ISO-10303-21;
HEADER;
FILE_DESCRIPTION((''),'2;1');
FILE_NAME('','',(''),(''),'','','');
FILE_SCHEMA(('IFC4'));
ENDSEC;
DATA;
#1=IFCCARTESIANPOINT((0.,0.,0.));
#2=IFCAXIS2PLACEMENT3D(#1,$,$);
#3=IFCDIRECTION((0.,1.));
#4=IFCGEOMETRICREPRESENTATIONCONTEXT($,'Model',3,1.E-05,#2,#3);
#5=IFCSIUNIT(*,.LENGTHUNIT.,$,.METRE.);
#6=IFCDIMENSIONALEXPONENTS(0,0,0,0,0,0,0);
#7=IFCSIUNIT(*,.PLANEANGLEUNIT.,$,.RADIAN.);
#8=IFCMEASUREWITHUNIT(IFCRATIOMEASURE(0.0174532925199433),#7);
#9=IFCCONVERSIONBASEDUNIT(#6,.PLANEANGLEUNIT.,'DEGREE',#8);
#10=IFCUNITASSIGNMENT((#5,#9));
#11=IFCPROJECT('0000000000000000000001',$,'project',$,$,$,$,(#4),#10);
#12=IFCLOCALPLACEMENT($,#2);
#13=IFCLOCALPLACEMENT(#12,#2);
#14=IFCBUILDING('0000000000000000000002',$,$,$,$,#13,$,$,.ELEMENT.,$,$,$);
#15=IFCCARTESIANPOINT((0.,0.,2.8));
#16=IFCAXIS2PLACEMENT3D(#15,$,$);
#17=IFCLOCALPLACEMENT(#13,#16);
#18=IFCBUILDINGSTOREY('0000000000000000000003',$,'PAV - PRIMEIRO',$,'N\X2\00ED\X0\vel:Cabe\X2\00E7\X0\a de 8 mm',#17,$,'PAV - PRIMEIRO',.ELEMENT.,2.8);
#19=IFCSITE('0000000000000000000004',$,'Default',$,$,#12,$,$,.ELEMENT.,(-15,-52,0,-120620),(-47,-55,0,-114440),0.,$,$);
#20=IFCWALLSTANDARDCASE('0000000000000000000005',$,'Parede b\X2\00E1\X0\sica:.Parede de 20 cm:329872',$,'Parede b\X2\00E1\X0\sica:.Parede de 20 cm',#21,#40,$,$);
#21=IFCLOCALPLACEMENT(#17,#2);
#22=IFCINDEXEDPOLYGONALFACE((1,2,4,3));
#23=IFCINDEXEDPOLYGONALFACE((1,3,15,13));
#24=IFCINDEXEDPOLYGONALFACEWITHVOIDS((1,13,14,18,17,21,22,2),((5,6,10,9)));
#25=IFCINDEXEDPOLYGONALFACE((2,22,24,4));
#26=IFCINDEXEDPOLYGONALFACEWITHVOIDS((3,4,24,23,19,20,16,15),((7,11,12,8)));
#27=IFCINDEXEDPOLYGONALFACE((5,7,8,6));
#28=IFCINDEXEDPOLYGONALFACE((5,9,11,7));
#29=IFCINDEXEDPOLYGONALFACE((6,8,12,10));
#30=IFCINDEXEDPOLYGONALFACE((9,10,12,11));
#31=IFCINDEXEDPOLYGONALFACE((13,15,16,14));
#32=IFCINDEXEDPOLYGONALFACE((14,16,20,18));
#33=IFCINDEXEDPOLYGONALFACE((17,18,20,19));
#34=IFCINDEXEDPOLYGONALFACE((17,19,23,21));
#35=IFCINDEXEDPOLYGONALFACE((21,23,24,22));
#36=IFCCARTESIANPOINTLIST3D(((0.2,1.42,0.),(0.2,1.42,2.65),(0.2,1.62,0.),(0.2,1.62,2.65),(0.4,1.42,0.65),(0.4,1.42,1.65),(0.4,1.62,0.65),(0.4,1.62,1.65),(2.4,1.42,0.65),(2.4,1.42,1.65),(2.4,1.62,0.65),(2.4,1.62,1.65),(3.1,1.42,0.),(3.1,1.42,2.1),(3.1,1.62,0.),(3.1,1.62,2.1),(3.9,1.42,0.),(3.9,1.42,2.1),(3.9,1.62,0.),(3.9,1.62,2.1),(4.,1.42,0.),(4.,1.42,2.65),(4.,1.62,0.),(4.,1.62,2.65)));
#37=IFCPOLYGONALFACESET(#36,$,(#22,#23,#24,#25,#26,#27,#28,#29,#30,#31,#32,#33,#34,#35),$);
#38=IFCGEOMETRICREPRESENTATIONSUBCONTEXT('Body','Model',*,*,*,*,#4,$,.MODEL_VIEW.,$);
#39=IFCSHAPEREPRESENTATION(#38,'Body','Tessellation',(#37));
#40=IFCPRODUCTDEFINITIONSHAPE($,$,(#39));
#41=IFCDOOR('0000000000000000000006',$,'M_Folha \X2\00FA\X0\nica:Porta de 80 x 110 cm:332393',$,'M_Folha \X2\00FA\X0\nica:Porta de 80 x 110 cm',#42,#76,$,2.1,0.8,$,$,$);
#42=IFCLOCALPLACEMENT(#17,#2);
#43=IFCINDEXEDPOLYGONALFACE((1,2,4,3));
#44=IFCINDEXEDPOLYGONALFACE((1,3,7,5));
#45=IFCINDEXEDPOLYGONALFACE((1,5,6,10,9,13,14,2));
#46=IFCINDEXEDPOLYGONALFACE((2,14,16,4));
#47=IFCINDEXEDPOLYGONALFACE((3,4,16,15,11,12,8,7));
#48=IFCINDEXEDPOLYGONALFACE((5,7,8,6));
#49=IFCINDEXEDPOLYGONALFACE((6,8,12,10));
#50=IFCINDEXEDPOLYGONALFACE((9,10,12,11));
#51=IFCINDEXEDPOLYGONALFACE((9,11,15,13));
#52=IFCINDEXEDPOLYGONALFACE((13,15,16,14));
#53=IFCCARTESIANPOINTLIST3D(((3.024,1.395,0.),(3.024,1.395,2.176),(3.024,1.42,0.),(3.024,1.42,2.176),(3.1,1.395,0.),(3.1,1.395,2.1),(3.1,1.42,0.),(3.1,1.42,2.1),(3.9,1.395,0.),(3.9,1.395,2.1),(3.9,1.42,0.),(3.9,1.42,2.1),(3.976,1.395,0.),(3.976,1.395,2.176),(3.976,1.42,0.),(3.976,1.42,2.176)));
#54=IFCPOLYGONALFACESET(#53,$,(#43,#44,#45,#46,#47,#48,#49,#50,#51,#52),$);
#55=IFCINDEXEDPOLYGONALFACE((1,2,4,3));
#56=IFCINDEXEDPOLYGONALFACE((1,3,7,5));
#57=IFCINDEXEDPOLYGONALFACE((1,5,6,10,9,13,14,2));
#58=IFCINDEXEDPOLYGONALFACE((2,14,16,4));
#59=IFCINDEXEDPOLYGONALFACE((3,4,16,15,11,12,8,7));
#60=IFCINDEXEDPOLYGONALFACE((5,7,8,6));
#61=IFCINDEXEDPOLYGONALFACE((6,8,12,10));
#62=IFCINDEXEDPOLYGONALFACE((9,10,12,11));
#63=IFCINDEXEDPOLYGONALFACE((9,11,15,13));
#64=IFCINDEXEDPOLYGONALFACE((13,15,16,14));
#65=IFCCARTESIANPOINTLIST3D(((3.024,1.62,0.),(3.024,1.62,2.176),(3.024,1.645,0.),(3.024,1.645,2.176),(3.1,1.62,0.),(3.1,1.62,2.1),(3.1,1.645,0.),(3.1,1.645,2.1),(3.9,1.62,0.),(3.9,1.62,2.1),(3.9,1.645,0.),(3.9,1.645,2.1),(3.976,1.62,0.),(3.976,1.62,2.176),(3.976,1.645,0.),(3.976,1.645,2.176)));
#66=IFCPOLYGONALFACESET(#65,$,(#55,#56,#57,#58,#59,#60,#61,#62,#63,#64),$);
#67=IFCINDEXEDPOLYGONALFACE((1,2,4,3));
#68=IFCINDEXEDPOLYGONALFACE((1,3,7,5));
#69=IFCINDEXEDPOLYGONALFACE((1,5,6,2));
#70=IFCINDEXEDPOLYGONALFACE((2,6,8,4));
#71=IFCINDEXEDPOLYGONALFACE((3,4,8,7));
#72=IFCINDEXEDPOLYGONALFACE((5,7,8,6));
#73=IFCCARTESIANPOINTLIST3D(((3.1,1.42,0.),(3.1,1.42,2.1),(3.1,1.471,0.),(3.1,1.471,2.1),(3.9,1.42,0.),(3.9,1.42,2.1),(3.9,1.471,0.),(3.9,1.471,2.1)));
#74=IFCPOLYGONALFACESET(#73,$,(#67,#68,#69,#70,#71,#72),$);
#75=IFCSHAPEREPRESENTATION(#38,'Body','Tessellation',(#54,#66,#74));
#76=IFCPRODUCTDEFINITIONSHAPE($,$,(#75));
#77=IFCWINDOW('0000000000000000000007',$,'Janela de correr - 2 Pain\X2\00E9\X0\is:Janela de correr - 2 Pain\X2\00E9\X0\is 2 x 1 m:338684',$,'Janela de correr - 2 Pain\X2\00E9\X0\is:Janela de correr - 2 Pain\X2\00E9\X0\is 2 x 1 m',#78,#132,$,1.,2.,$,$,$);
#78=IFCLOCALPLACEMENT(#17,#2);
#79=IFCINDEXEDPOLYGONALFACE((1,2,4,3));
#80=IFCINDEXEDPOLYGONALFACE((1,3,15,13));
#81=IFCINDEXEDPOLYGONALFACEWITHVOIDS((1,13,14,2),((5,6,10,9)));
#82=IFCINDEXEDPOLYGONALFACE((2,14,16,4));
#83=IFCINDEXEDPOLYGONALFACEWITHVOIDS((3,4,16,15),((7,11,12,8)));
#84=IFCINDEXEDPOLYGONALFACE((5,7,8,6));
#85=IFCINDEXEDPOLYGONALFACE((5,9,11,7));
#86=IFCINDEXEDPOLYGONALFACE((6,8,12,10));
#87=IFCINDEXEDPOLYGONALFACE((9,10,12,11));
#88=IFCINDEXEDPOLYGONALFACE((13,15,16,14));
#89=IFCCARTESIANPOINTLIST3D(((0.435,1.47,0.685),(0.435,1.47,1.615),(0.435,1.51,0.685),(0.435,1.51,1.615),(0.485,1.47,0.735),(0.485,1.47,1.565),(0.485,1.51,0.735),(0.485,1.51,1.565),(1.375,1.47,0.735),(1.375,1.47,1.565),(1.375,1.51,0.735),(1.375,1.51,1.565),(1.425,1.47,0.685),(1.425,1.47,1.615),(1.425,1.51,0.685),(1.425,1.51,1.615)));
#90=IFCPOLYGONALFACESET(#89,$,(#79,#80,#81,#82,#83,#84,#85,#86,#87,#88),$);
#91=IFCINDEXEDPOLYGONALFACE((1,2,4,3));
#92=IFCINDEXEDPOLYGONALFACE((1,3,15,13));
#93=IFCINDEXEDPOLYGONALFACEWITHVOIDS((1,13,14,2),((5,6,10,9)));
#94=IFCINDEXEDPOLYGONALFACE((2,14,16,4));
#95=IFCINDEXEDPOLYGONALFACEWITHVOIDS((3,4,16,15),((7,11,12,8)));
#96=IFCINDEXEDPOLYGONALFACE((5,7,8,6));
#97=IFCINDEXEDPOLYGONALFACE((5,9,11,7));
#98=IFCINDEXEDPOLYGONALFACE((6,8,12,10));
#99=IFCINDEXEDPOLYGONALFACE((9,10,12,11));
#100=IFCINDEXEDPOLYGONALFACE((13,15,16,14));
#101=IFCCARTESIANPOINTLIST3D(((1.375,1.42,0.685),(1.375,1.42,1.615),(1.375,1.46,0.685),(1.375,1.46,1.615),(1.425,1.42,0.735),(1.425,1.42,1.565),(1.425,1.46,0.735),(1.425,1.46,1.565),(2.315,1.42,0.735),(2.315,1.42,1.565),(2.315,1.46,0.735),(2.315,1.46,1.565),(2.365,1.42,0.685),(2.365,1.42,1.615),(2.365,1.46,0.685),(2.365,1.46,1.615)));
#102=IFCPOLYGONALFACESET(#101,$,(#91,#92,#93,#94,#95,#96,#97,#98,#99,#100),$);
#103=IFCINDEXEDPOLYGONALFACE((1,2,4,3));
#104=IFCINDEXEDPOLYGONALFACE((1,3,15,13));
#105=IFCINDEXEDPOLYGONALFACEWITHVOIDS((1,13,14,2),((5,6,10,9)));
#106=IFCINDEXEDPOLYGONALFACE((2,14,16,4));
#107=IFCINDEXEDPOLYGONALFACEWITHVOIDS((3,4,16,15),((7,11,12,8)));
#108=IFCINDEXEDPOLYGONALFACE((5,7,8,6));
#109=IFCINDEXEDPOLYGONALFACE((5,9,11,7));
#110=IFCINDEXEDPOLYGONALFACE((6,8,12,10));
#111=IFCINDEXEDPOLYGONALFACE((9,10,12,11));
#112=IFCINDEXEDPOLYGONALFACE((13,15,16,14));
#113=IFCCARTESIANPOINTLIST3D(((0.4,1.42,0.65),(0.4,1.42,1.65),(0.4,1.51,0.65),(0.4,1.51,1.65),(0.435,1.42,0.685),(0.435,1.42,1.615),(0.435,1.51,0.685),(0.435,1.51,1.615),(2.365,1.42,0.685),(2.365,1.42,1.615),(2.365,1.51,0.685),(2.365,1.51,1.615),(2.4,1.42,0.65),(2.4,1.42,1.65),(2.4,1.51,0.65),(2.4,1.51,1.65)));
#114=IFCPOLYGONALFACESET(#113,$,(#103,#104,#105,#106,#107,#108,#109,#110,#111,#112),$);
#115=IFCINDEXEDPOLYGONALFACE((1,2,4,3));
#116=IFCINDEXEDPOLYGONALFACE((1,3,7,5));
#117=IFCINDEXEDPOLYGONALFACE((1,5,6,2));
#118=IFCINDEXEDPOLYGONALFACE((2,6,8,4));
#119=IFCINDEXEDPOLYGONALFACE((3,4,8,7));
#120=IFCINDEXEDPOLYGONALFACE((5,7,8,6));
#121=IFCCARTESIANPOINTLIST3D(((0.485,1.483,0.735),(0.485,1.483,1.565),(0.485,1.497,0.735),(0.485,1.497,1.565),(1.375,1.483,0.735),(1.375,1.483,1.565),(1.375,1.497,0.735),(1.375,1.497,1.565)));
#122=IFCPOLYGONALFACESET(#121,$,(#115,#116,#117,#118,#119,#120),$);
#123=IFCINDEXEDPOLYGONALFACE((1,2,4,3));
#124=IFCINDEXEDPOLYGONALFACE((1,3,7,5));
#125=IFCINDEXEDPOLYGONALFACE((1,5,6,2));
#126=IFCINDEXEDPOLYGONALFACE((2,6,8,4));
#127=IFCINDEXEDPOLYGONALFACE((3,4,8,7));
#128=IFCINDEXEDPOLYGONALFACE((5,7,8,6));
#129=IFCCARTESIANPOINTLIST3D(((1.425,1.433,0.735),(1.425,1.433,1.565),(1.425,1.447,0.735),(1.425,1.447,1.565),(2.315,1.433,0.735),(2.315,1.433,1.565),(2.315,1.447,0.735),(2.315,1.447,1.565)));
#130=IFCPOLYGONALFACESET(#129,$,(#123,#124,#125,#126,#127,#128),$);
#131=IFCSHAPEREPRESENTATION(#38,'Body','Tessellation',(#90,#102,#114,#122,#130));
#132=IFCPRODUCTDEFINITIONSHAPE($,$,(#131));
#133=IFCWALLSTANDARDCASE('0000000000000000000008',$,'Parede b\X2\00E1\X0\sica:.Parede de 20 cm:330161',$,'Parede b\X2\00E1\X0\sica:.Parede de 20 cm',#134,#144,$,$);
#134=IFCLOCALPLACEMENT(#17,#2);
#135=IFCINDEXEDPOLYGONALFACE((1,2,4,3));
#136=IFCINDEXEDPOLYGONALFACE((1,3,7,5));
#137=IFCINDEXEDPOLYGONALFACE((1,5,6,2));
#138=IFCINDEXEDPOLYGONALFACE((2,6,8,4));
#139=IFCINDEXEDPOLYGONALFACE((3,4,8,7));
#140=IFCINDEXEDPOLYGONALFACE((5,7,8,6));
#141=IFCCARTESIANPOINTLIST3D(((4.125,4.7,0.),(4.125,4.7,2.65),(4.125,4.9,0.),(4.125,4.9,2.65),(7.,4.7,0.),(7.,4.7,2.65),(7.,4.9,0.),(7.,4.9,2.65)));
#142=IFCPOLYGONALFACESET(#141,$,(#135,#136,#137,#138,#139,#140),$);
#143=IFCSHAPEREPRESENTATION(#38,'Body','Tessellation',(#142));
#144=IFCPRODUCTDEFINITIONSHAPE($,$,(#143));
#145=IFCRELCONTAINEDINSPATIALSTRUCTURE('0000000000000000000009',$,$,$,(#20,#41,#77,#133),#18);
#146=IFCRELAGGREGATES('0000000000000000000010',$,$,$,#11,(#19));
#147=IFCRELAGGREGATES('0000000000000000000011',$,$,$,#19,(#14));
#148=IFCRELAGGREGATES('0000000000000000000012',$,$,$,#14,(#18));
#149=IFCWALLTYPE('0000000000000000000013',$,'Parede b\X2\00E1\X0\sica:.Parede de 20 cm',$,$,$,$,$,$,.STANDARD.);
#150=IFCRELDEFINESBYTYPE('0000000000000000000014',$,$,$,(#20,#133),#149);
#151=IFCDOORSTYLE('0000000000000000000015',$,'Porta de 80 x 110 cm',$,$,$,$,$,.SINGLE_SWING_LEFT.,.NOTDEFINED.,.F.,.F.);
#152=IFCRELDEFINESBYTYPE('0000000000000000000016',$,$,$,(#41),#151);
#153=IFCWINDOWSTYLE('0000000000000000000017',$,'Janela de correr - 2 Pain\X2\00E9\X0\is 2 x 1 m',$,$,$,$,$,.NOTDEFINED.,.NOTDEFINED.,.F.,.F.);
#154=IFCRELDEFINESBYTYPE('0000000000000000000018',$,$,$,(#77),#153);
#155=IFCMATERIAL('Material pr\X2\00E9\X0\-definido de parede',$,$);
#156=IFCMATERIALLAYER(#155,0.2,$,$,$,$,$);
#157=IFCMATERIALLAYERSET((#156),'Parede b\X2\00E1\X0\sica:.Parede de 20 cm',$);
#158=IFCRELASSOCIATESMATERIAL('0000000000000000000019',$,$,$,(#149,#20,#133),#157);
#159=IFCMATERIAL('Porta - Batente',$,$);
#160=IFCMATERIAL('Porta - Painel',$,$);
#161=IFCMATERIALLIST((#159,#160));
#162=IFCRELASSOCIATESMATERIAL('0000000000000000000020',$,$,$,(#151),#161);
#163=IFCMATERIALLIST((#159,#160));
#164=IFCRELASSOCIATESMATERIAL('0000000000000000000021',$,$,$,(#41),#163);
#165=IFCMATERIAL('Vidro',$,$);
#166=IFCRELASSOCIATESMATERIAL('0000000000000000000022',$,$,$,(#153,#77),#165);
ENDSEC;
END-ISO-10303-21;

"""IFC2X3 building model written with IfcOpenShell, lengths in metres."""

from ifc_helpers import new_model, entity, si_unit, converted_unit, direction, frame, frame_2d, origin, origin_2d_with_axis, place, context, subcontext, project, spatial, polyline, rectangle, outline, extrude, clip, bounded_halfspace, source, transform, mapped, material, material_list, layer, layer_set, layer_usage, type_object, type_shapes, element, fill, save


model = new_model("IFC2X3")

# Units and contexts
model_context = context("Model", 3, precision=1e-05, world=origin(), true_north=direction((0.0, 1.0)))
body_context = subcontext(model_context, "Body", "Model", "MODEL_VIEW")
ifc_project = project(units=[si_unit("LENGTHUNIT", "METRE"), converted_unit("PLANEANGLEUNIT", "DEGREE", entity("IfcRatioMeasure", 0.0174532925199433), si_unit("PLANEANGLEUNIT", "RADIAN"), dimensions=[0, 0, 0, 0, 0, 0, 0])], contexts=[model_context])

# Site, building, storey
site_placement = place(None, origin())
site = spatial("IfcSite", under=ifc_project, at=site_placement, Name="Default", CompositionType="ELEMENT", RefLatitude=(-15, -52, 0, -120620), RefLongitude=(-47, -55, 0, -114440), RefElevation=0.0)
building_placement = place(site_placement, origin())
building = spatial("IfcBuilding", under=site, at=building_placement, CompositionType="ELEMENT")
storey_placement = place(building_placement, frame((0.0, 0.0, 2.8)))
storey = spatial("IfcBuildingStorey", under=building, at=storey_placement, Name="PAV - PRIMEIRO", ObjectType="Nível:Cabeça de 8 mm", LongName="PAV - PRIMEIRO", CompositionType="ELEMENT", Elevation=2.8)

# Shared definitions
ifc_material_1 = material(Name="Material pré-definido de parede")
ifc_layer_1 = layer(ifc_material_1, 0.2)
ifc_layer_set_1 = layer_set([ifc_layer_1], Name="Parede básica:.Parede de 20 cm")
wall_type_1 = type_object("IfcWallType", Name="Parede básica:.Parede de 20 cm", PredefinedType="STANDARD", material=ifc_layer_set_1)

# Shared definitions
ifc_material_2 = material(Name="Vidro")

# Wall, openings, door, window
ifc_layer_usage_1 = layer_usage(ifc_layer_set_1, "AXIS2", "NEGATIVE", 0.1)
wall_1_placement = place(storey_placement, frame((0.2, 1.52, 0.0)))
wall_1 = element("IfcWallStandardCase", 1, at=wall_1_placement, inside=storey, type_object=wall_type_1, material=ifc_layer_usage_1, Name="Parede básica:.Parede de 20 cm:329872", ObjectType="Parede básica:.Parede de 20 cm", context=body_context, shape_type="Clipping", body=[
    clip(extrude(rectangle(XDim=3.8, YDim=0.2, at=frame_2d((1.9, 0.0), x_axis=(-1.0, 0.0))), origin(), (0.0, 0.0, 1.0), 2.65), bounded_halfspace(frame((0.0, -0.1, 2.65), z_axis=(0.0, 0.0, -1.0), x_axis=(0.0, -1.0, 0.0)), True, frame((0.0, -0.1, 2.65)), polyline([(0.0, 0.0), (3.8, 0.0), (3.8, 0.2), (0.0, 0.2), (0.0, 0.0)]))),
])
opening_1_placement = place(wall_1_placement, frame((3.7, 0.1, 0.0)))
opening_1 = element("IfcOpeningElement", 2, at=opening_1_placement, cuts=wall_1, ObjectType="Opening", context=body_context, shape_type="SweptSolid", body=[
    extrude(rectangle(XDim=0.8, YDim=2.1, at=frame_2d((1.05, 0.4), x_axis=(0.0, -1.0))), frame((0.0, 0.0, 0.0), z_axis=(0.0, -1.0, 0.0), x_axis=(0.0, 0.0, 1.0)), (0.0, 0.0, 1.0), 0.2),
])
opening_2_placement = place(wall_1_placement, frame((0.2, -0.1, 0.65)))
opening_2 = element("IfcOpeningElement", 3, at=opening_2_placement, cuts=wall_1, ObjectType="Opening", context=body_context, shape_type="SweptSolid", body=[
    extrude(rectangle(XDim=1.0, YDim=2.0, at=frame_2d((0.5, 1.0), x_axis=(1.0, 0.0))), frame((0.0, 0.0, 0.0), z_axis=(0.0, 1.0, 0.0), x_axis=(0.0, 0.0, 1.0)), (0.0, 0.0, 1.0), 0.2),
])
ifc_material_3 = material(Name="Porta - Batente")
ifc_material_4 = material(Name="Porta - Painel")
ifc_material_list_1 = material_list([ifc_material_3, ifc_material_4])
ifc_material_list_2 = material_list([ifc_material_3, ifc_material_4])
door_style_1 = type_object("IfcDoorStyle", Name="Porta de 80 x 110 cm", ConstructionType="NOTDEFINED", OperationType="SINGLE_SWING_LEFT", ParameterTakesPrecedence=False, Sizeable=False, material=ifc_material_list_2)
shared_shape_1 = source(origin(), body_context, "Body", "SweptSolid", [
    extrude(outline(polyline([(-0.476, -1.107), (0.476, -1.107), (0.476, 1.069), (0.4, 1.069), (0.4, -1.031), (-0.4, -1.031), (-0.4, 1.069), (-0.476, 1.069), (-0.476, -1.107)])), frame((0.4, 0.225, 1.069), z_axis=(0.0, -1.0, 0.0), x_axis=(-1.0, 0.0, 0.0)), (0.0, 0.0, 1.0), 0.025),
    extrude(outline(polyline([(-1.107, -0.476), (1.069, -0.476), (1.069, -0.4), (-1.031, -0.4), (-1.031, 0.4), (1.069, 0.4), (1.069, 0.476), (-1.107, 0.476), (-1.107, -0.476)])), frame((0.4, 0.0, 1.069), z_axis=(0.0, -1.0, 0.0), x_axis=(0.0, 0.0, -1.0)), (0.0, 0.0, 1.0), 0.025),
    extrude(rectangle(XDim=0.8, YDim=0.051, at=frame_2d((0.0, 0.0), x_axis=(1.0, 0.0))), frame((0.4, 0.1745, 0.0)), (0.0, 0.0, 1.0), 2.1),
])
type_shapes(door_style_1, [shared_shape_1])
door_1_placement = place(opening_1_placement, frame((0.0, 0.0, 0.0), z_axis=(0.0, 0.0, 1.0), x_axis=(-1.0, 0.0, 0.0)))
door_1 = element("IfcDoor", 4, at=door_1_placement, inside=storey, type_object=door_style_1, material=ifc_material_list_1, Name="M_Folha única:Porta de 80 x 110 cm:332393", ObjectType="M_Folha única:Porta de 80 x 110 cm", OverallHeight=2.1, OverallWidth=0.8, context=body_context, shape_type="MappedRepresentation", body=[
    mapped(shared_shape_1, transform((0.0, 0.0, 0.0), scale=1.0)),
])
fill(opening_1, door_1)
window_style_1 = type_object("IfcWindowStyle", Name="Janela de correr - 2 Painéis 2 x 1 m", ConstructionType="NOTDEFINED", OperationType="NOTDEFINED", ParameterTakesPrecedence=False, Sizeable=False, material=ifc_material_2)
shared_shape_2 = source(origin(), body_context, "Body", "SweptSolid", [
    extrude(outline(polyline([(-0.495, -0.465), (0.495, -0.465), (0.495, 0.465), (-0.495, 0.465), (-0.495, -0.465)]), holes=[polyline([(-0.445, 0.415), (0.445, 0.415), (0.445, -0.415), (-0.445, -0.415), (-0.445, 0.415)])]), frame((0.53, 0.09, 0.5), z_axis=(0.0, -1.0, 0.0), x_axis=(-1.0, 0.0, 0.0)), (0.0, 0.0, 1.0), 0.04),
    extrude(outline(polyline([(-0.495, -0.465), (0.495, -0.465), (0.495, 0.465), (-0.495, 0.465), (-0.495, -0.465)]), holes=[polyline([(-0.445, 0.415), (0.445, 0.415), (0.445, -0.415), (-0.445, -0.415), (-0.445, 0.415)])]), frame((1.47, 0.04, 0.5), z_axis=(0.0, -1.0, 0.0), x_axis=(1.0, 0.0, 0.0)), (0.0, 0.0, 1.0), 0.04),
    extrude(outline(polyline([(-1.0, -0.5), (1.0, -0.5), (1.0, 0.5), (-1.0, 0.5), (-1.0, -0.5)]), holes=[polyline([(-0.965, 0.465), (0.965, 0.465), (0.965, -0.465), (-0.965, -0.465), (-0.965, 0.465)])]), frame((1.0, 0.09, 0.5), z_axis=(0.0, -1.0, 0.0), x_axis=(1.0, 0.0, 0.0)), (0.0, 0.0, 1.0), 0.09),
    extrude(rectangle(XDim=0.89, YDim=0.014, at=frame_2d((0.0, 0.0), x_axis=(1.0, 0.0))), frame((0.53, 0.07, 0.085), z_axis=(0.0, 0.0, 1.0), x_axis=(-1.0, 0.0, 0.0)), (0.0, 0.0, 1.0), 0.83),
    extrude(rectangle(XDim=0.89, YDim=0.014, at=origin_2d_with_axis()), frame((1.47, 0.02, 0.085), z_axis=(0.0, 0.0, 1.0), x_axis=(-1.0, 0.0, 0.0)), (0.0, 0.0, 1.0), 0.83),
])
type_shapes(window_style_1, [shared_shape_2])
window_1_placement = place(opening_2_placement, origin())
window_1 = element("IfcWindow", 5, at=window_1_placement, inside=storey, type_object=window_style_1, material=ifc_material_2, Name="Janela de correr - 2 Painéis:Janela de correr - 2 Painéis 2 x 1 m:338684", ObjectType="Janela de correr - 2 Painéis:Janela de correr - 2 Painéis 2 x 1 m", OverallHeight=1.0, OverallWidth=2.0, context=body_context, shape_type="MappedRepresentation", body=[
    mapped(shared_shape_2, transform((0.0, 0.0, 0.0), scale=1.0)),
])
fill(opening_2, window_1)

# Wall
ifc_layer_usage_2 = layer_usage(ifc_layer_set_1, "AXIS2", "NEGATIVE", 0.1)
wall_2_placement = place(storey_placement, frame((4.125, 4.8, 0.0)))
element("IfcWallStandardCase", 6, at=wall_2_placement, inside=storey, type_object=wall_type_1, material=ifc_layer_usage_2, Name="Parede básica:.Parede de 20 cm:330161", ObjectType="Parede básica:.Parede de 20 cm", context=body_context, shape_type="Clipping", body=[
    clip(extrude(rectangle(XDim=2.875, YDim=0.2, at=frame_2d((1.4375, 0.0), x_axis=(-1.0, 0.0))), origin(), (0.0, 0.0, 1.0), 2.65), bounded_halfspace(frame((0.0, -0.1, 2.65), z_axis=(0.0, 0.0, -1.0), x_axis=(0.0, -1.0, 0.0)), True, frame((0.0, -0.1, 2.65)), polyline([(0.0, 0.0), (0.075, 0.0), (2.875, 0.0), (2.875, 0.2), (0.65, 0.2), (0.5, 0.2), (0.0, 0.2), (0.0, 0.14), (0.0, 0.0)]))),
])

save(model, "model.ifc")
